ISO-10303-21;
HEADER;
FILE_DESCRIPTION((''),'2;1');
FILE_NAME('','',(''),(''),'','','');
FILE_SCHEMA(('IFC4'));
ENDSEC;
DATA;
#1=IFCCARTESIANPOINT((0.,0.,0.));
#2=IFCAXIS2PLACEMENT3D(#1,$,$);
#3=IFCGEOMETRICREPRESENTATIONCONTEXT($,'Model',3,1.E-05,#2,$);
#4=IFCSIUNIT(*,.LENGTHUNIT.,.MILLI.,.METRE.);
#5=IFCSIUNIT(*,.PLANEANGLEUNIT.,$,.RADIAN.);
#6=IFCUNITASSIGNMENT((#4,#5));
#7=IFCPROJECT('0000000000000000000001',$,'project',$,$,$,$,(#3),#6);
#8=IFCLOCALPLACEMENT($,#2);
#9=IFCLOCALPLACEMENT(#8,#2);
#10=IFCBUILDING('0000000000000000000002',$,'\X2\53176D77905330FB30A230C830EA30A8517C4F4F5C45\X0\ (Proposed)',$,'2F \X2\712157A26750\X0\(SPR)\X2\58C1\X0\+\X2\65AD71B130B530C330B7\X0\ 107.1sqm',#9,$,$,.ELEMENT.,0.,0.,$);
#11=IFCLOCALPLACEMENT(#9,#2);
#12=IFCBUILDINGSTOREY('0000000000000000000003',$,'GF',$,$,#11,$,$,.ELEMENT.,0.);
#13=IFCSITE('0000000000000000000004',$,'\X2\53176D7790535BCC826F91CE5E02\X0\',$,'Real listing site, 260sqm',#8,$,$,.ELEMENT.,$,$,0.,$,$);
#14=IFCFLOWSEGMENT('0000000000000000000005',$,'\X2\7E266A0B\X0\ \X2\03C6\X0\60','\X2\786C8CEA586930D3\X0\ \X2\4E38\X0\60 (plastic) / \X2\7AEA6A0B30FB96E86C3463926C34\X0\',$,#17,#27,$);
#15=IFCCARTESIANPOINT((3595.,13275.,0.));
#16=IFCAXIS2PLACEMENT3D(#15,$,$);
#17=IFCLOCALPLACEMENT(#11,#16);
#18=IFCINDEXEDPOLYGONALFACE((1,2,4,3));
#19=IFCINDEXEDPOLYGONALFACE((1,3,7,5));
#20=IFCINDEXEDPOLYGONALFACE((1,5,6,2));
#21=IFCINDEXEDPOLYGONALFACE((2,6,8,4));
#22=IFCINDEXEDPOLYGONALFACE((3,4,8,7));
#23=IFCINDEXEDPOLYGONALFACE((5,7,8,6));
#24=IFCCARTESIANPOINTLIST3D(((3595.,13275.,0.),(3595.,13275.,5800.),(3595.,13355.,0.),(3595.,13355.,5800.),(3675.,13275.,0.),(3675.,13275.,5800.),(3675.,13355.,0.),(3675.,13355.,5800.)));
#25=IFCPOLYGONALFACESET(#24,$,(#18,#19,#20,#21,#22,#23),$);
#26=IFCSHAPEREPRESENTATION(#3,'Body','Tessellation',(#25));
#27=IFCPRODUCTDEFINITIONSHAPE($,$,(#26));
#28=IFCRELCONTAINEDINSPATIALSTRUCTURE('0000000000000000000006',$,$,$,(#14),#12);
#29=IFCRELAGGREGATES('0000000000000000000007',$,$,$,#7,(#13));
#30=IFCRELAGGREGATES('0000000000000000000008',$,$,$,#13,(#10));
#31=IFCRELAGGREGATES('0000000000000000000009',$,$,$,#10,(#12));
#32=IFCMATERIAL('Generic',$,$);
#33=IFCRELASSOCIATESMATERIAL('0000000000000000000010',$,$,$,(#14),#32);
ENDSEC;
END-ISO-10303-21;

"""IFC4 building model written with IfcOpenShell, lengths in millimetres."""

from ifc_helpers import new_model, si_unit, frame, frame_2d, origin, place, context, project, spatial, rectangle, extrude, material, element, save


model = new_model("IFC4")

# Units and contexts
model_context = context("Model", 3, precision=1e-05, world=origin())
ifc_project = project(units=[si_unit("LENGTHUNIT", "METRE", prefix="MILLI"), si_unit("PLANEANGLEUNIT", "RADIAN")], contexts=[model_context])

# Site, building, storey
site_placement = place(None, origin())
site = spatial("IfcSite", under=ifc_project, at=site_placement, Name="北海道富良野市", ObjectType="Real listing site, 260sqm", CompositionType="ELEMENT", RefElevation=0.0)
building_placement = place(site_placement, origin())
building = spatial("IfcBuilding", under=site, at=building_placement, Name="北海道・アトリエ兼住居 (Proposed)", ObjectType="2F 無垢材(SPR)壁+断熱サッシ 107.1sqm", CompositionType="ELEMENT", ElevationOfRefHeight=0.0, ElevationOfTerrain=0.0)
storey_placement = place(building_placement, origin())
storey = spatial("IfcBuildingStorey", under=building, at=storey_placement, Name="GF", CompositionType="ELEMENT", Elevation=0.0)

# Shared definitions
ifc_material_1 = material(Name="Generic")

# Flow segment
flow_segment_placement = place(storey_placement, frame((3595.0, 13275.0, 0.0)))
element("IfcFlowSegment", 1, at=flow_segment_placement, inside=storey, material=ifc_material_1, Name="縦樋 φ60", Description="硬質塩ビ 丸60 (plastic) / 竪樋・雨水排水", context=model_context, shape_type="SweptSolid", body=[
    extrude(rectangle(XDim=80.0, YDim=80.0, at=frame_2d((40.0, 40.0))), frame((3595.0, 13275.0, 0.0)), (0.0, 0.0, 1.0), 5800.0),
])

save(model, "model.ifc")
